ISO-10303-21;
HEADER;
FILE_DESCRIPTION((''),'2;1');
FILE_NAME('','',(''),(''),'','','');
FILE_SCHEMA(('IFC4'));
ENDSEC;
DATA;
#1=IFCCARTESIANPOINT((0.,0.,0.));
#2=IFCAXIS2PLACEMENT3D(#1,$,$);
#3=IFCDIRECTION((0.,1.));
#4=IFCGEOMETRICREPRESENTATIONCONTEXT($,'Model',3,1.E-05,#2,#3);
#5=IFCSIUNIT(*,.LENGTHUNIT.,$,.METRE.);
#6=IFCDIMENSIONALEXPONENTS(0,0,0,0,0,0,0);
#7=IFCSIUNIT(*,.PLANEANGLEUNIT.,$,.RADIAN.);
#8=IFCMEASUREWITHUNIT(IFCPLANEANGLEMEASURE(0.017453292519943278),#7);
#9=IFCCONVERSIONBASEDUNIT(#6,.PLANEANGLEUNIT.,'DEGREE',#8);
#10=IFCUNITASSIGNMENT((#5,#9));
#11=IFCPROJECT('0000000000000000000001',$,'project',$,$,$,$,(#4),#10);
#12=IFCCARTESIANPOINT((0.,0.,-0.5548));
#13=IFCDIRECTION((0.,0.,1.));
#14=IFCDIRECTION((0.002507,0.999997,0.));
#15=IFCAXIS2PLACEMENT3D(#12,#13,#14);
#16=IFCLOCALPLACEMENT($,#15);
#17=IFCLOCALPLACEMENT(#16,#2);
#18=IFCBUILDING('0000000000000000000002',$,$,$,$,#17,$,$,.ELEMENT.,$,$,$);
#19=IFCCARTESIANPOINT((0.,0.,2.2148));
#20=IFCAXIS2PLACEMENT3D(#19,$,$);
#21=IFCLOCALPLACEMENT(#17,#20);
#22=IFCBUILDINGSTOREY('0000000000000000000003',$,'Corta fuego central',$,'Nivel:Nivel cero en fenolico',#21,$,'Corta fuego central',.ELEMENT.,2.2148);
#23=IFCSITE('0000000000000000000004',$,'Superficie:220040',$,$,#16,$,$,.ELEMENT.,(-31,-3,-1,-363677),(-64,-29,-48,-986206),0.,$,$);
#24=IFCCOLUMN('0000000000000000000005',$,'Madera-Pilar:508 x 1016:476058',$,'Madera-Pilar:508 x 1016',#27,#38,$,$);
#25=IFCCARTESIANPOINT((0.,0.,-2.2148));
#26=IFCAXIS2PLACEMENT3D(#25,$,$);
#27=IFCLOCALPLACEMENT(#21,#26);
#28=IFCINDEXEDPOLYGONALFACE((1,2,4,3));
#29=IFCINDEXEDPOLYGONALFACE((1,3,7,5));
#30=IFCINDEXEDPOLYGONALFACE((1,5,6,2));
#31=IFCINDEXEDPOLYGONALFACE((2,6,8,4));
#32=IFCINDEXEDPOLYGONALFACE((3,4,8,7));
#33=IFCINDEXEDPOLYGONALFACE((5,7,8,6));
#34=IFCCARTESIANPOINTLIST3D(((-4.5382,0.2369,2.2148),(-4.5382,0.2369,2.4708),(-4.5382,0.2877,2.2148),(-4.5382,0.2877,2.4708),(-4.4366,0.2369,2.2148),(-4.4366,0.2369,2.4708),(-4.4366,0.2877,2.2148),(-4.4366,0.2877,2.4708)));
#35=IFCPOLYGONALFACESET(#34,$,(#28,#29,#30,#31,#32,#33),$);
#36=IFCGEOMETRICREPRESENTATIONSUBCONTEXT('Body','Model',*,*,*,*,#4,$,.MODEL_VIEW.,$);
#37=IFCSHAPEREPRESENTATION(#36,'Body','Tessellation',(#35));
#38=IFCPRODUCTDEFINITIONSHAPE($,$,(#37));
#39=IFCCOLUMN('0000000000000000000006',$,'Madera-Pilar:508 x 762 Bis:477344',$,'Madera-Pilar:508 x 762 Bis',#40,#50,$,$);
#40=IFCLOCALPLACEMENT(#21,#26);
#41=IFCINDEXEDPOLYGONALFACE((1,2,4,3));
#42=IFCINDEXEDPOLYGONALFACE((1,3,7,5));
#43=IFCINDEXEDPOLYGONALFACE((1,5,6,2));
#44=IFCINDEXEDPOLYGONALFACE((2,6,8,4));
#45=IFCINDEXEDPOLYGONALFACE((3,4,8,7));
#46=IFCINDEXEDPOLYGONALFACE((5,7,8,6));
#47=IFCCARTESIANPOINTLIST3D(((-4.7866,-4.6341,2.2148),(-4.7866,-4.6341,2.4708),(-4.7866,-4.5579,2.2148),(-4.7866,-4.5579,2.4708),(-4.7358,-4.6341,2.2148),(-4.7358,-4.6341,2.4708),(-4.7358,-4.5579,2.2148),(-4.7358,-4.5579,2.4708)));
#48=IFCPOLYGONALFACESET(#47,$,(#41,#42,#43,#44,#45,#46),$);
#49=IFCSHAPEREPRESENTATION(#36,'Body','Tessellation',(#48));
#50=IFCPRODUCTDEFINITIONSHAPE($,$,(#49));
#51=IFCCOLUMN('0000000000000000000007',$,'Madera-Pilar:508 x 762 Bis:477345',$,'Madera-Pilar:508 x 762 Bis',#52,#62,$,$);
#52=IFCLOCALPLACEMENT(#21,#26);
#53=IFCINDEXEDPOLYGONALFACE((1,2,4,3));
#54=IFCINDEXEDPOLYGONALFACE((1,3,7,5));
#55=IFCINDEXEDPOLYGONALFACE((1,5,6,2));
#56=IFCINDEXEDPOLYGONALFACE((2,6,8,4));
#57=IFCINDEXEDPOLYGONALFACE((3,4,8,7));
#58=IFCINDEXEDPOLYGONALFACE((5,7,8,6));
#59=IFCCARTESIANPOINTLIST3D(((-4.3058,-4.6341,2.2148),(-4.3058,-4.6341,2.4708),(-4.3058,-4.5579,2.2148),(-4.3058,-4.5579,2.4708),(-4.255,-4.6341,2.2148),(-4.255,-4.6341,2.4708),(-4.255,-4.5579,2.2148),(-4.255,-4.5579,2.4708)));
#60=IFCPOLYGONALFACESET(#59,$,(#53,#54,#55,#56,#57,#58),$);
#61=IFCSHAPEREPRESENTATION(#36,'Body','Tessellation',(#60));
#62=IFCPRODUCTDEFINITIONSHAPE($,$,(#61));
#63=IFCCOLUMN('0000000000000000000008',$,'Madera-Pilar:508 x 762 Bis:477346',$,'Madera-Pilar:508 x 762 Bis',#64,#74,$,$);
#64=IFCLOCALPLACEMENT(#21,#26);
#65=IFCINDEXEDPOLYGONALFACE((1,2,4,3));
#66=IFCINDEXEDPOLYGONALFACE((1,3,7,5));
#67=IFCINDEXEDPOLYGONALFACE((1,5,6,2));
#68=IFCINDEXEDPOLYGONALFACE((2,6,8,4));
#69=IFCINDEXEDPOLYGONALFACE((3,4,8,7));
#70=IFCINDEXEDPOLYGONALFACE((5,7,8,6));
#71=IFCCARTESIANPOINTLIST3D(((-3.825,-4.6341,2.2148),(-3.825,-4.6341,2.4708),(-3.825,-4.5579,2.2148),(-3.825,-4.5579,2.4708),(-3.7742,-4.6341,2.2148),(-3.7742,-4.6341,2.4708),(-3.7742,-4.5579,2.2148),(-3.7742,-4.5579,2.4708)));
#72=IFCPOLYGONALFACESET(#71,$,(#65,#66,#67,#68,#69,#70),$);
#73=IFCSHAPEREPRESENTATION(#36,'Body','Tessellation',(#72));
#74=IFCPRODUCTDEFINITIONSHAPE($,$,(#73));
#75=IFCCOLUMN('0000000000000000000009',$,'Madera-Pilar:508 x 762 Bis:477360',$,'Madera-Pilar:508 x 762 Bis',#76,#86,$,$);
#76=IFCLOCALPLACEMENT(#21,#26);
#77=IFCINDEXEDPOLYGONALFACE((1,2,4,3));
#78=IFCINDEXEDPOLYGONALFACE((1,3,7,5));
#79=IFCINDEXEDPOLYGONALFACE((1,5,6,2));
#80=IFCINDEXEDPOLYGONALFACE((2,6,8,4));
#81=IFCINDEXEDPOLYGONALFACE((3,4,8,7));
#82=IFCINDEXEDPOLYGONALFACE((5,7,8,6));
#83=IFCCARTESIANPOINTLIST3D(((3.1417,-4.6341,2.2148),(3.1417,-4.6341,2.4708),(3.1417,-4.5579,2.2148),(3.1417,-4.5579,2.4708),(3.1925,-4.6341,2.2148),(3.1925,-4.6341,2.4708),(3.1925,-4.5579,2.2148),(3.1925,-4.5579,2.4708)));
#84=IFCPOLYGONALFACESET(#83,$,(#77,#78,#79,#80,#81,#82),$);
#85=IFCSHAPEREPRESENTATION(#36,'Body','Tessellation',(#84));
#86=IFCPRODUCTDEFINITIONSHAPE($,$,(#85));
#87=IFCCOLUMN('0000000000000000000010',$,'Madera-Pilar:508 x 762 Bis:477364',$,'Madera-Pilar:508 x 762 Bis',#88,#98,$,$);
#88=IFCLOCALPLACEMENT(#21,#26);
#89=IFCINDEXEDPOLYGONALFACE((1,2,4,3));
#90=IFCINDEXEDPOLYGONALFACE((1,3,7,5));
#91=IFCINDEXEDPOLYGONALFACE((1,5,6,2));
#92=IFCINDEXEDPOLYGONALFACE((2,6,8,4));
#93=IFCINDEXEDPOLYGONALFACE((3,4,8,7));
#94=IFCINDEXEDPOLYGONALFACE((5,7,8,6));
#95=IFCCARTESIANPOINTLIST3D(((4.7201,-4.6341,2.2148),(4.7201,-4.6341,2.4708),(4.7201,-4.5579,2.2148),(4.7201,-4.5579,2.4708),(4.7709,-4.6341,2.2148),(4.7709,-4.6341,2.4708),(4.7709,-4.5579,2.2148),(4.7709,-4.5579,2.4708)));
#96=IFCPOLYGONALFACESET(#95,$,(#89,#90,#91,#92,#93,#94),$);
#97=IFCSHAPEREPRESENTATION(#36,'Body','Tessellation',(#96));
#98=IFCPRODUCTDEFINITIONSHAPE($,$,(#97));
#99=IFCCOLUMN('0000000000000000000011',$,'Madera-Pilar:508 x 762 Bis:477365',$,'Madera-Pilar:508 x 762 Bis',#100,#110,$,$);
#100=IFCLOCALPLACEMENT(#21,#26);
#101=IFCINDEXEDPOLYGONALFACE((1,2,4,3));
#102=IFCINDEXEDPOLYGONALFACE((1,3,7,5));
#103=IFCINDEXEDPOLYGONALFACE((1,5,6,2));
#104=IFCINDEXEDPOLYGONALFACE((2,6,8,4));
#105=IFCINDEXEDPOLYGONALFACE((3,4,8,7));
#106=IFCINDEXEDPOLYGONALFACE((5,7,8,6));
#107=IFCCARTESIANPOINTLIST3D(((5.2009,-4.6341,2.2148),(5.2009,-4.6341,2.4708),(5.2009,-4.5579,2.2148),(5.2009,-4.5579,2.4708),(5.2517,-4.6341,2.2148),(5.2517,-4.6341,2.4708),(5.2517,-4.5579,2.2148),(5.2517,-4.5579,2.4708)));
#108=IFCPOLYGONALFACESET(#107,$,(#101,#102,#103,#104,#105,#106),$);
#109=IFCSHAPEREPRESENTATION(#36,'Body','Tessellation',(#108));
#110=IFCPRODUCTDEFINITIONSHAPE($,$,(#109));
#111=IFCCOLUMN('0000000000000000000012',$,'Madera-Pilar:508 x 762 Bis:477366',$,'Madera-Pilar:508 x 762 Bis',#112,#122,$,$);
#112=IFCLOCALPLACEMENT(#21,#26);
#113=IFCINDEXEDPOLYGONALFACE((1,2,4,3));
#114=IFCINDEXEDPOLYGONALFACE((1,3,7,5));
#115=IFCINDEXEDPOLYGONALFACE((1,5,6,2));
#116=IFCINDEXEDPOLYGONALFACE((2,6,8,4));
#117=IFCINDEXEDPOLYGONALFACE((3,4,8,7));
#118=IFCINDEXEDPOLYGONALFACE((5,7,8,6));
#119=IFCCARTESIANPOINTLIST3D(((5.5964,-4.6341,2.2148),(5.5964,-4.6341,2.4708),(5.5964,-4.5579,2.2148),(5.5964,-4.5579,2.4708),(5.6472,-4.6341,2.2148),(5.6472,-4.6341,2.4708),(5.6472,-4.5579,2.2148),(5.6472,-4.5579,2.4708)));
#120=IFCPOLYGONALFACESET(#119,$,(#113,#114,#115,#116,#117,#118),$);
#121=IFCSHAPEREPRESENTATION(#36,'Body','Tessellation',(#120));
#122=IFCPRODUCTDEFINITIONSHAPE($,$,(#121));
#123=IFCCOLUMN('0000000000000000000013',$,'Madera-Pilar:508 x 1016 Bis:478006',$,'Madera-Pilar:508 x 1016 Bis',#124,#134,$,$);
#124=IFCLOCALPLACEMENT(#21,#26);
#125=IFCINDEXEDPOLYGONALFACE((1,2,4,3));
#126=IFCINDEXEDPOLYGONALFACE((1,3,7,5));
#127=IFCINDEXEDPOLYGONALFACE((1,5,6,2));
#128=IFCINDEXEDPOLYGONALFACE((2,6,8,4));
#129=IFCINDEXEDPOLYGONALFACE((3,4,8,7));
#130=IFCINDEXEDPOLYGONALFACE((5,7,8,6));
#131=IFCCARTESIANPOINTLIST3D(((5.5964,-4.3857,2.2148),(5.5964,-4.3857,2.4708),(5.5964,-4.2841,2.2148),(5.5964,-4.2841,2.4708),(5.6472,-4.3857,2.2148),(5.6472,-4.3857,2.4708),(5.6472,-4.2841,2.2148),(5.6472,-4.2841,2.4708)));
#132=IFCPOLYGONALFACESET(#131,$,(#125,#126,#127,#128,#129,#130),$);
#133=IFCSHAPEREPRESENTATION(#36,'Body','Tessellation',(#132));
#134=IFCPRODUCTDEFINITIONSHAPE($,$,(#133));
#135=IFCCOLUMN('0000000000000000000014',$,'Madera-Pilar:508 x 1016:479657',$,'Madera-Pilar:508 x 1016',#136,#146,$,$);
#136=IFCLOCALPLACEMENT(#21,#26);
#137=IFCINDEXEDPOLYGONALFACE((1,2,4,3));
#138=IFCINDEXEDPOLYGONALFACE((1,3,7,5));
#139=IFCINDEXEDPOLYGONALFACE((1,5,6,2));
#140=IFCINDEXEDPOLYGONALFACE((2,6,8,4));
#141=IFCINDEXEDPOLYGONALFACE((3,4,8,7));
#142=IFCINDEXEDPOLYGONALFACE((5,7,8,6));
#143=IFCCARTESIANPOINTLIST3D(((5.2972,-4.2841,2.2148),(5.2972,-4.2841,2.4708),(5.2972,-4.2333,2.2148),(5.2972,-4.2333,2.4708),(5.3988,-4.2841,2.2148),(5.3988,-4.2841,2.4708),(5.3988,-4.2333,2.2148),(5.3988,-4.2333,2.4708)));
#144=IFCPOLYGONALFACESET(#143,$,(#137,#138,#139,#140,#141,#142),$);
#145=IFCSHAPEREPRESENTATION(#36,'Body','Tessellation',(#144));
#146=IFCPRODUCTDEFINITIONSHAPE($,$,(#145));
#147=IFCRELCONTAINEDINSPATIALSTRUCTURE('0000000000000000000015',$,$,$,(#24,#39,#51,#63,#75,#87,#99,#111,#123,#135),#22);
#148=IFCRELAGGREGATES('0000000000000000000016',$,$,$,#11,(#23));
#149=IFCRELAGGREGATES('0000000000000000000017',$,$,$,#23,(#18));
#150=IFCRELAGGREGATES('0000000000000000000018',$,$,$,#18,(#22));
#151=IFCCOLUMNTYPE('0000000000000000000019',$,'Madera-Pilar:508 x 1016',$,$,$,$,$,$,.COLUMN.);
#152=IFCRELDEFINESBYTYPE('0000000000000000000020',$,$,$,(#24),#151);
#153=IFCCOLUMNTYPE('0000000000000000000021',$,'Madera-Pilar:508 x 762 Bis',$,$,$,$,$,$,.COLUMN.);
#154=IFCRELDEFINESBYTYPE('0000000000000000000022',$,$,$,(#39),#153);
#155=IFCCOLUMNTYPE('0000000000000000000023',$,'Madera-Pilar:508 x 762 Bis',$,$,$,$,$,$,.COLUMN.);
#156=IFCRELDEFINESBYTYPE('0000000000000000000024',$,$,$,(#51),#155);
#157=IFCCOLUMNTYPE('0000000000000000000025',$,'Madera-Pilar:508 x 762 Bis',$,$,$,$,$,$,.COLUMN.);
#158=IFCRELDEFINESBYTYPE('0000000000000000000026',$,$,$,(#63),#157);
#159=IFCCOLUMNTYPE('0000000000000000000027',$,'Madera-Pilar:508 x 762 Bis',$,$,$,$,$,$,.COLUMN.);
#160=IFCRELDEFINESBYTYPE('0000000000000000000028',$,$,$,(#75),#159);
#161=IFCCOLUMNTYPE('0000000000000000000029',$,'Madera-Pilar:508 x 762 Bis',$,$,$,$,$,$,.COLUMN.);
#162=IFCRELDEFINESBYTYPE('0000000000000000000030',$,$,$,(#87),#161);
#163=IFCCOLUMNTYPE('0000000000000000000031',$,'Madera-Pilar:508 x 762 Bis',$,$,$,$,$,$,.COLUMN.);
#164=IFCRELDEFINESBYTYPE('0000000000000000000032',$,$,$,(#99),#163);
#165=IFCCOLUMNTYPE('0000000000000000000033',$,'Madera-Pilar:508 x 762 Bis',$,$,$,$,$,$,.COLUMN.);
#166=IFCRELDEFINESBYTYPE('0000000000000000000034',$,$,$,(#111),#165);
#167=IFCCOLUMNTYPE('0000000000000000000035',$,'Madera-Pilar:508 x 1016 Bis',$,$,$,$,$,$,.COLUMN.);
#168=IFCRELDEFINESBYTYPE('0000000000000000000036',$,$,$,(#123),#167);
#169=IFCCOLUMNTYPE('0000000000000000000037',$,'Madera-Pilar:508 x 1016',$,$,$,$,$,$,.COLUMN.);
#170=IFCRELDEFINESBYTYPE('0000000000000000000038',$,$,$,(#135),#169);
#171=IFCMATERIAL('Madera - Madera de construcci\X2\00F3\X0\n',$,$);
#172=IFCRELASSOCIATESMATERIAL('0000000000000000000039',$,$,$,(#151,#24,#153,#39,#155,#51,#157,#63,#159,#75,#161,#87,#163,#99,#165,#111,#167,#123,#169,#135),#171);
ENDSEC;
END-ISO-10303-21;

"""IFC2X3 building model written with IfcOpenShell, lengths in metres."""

from ifc_helpers import new_model, entity, si_unit, converted_unit, direction, frame, frame_2d, origin, origin_2d_with_axis, place, context, subcontext, project, spatial, rectangle, extrude, source, transform, mapped, material, type_object, type_shapes, element, save


model = new_model("IFC2X3")

# Units and contexts
model_context = context("Model", 3, precision=1e-05, world=origin(), true_north=direction((0.0, 1.0)))
body_context = subcontext(model_context, "Body", "Model", "MODEL_VIEW")
ifc_project = project(units=[si_unit("LENGTHUNIT", "METRE"), converted_unit("PLANEANGLEUNIT", "DEGREE", entity("IfcPlaneAngleMeasure", 0.017453292519943278), si_unit("PLANEANGLEUNIT", "RADIAN"), dimensions=[0, 0, 0, 0, 0, 0, 0])], contexts=[model_context])

# Site, building, storey
site_placement = place(None, frame((0.0, 0.0, -0.5548), z_axis=(0.0, 0.0, 1.0), x_axis=(0.002507, 0.999997, 0.0)))
site = spatial("IfcSite", under=ifc_project, at=site_placement, Name="Superficie:220040", CompositionType="ELEMENT", RefLatitude=(-31, -3, -1, -363677), RefLongitude=(-64, -29, -48, -986206), RefElevation=0.0)
building_placement = place(site_placement, origin())
building = spatial("IfcBuilding", under=site, at=building_placement, CompositionType="ELEMENT")
storey_placement = place(building_placement, frame((0.0, 0.0, 2.2148)))
storey = spatial("IfcBuildingStorey", under=building, at=storey_placement, Name="Corta fuego central", ObjectType="Nivel:Nivel cero en fenolico", LongName="Corta fuego central", CompositionType="ELEMENT", Elevation=2.2148)

# Columns
ifc_material = material(Name="Madera - Madera de construcción")
column_type_1 = type_object("IfcColumnType", Name="Madera-Pilar:508 x 1016", PredefinedType="COLUMN", material=ifc_material)
shared_shape_1 = source(origin(), body_context, "Body", "SweptSolid", [
    extrude(rectangle(XDim=0.1016, YDim=0.0508, at=frame_2d((0.0, 0.0), x_axis=(1.0, 0.0))), frame((-4.4874, 0.2623, 2.2148), z_axis=(0.0, 0.0, 1.0), x_axis=(-1.0, 0.0, 0.0)), (0.0, 0.0, 1.0), 0.256),
])
type_shapes(column_type_1, [shared_shape_1])
column_1_placement = place(storey_placement, frame((0.0, 0.0, -2.2148)))
element("IfcColumn", 1, at=column_1_placement, inside=storey, type_object=column_type_1, material=ifc_material, Name="Madera-Pilar:508 x 1016:476058", ObjectType="Madera-Pilar:508 x 1016", context=body_context, shape_type="MappedRepresentation", body=[
    mapped(shared_shape_1, transform((0.0, 0.0, 0.0), scale=1.0)),
])
column_type_2 = type_object("IfcColumnType", Name="Madera-Pilar:508 x 762 Bis", PredefinedType="COLUMN", material=ifc_material)
shared_shape_2 = source(origin(), body_context, "Body", "SweptSolid", [
    extrude(rectangle(XDim=0.0508, YDim=0.0762, at=frame_2d((0.0, 0.0), x_axis=(1.0, 0.0))), frame((-4.7612, -4.596, 2.2148)), (0.0, 0.0, 1.0), 0.256),
])
type_shapes(column_type_2, [shared_shape_2])
column_2_placement = place(storey_placement, frame((0.0, 0.0, -2.2148)))
element("IfcColumn", 2, at=column_2_placement, inside=storey, type_object=column_type_2, material=ifc_material, Name="Madera-Pilar:508 x 762 Bis:477344", ObjectType="Madera-Pilar:508 x 762 Bis", context=body_context, shape_type="MappedRepresentation", body=[
    mapped(shared_shape_2, transform((0.0, 0.0, 0.0), scale=1.0)),
])
column_type_3 = type_object("IfcColumnType", Name="Madera-Pilar:508 x 762 Bis", PredefinedType="COLUMN", material=ifc_material)
shared_shape_3 = source(origin(), body_context, "Body", "SweptSolid", [
    extrude(rectangle(XDim=0.0508, YDim=0.0762, at=frame_2d((0.0, 0.0), x_axis=(1.0, 0.0))), frame((-4.2804, -4.596, 2.2148)), (0.0, 0.0, 1.0), 0.256),
])
type_shapes(column_type_3, [shared_shape_3])
column_3_placement = place(storey_placement, frame((0.0, 0.0, -2.2148)))
element("IfcColumn", 3, at=column_3_placement, inside=storey, type_object=column_type_3, material=ifc_material, Name="Madera-Pilar:508 x 762 Bis:477345", ObjectType="Madera-Pilar:508 x 762 Bis", context=body_context, shape_type="MappedRepresentation", body=[
    mapped(shared_shape_3, transform((0.0, 0.0, 0.0), scale=1.0)),
])
column_type_4 = type_object("IfcColumnType", Name="Madera-Pilar:508 x 762 Bis", PredefinedType="COLUMN", material=ifc_material)
shared_shape_4 = source(origin(), body_context, "Body", "SweptSolid", [
    extrude(rectangle(XDim=0.0508, YDim=0.0762, at=frame_2d((0.0, 0.0), x_axis=(1.0, 0.0))), frame((-3.7996, -4.596, 2.2148)), (0.0, 0.0, 1.0), 0.256),
])
type_shapes(column_type_4, [shared_shape_4])
column_4_placement = place(storey_placement, frame((0.0, 0.0, -2.2148)))
element("IfcColumn", 4, at=column_4_placement, inside=storey, type_object=column_type_4, material=ifc_material, Name="Madera-Pilar:508 x 762 Bis:477346", ObjectType="Madera-Pilar:508 x 762 Bis", context=body_context, shape_type="MappedRepresentation", body=[
    mapped(shared_shape_4, transform((0.0, 0.0, 0.0), scale=1.0)),
])
column_type_5 = type_object("IfcColumnType", Name="Madera-Pilar:508 x 762 Bis", PredefinedType="COLUMN", material=ifc_material)
shared_shape_5 = source(origin(), body_context, "Body", "SweptSolid", [
    extrude(rectangle(XDim=0.0508, YDim=0.0762, at=frame_2d((0.0, 0.0), x_axis=(1.0, 0.0))), frame((3.1671, -4.596, 2.2148)), (0.0, 0.0, 1.0), 0.256),
])
type_shapes(column_type_5, [shared_shape_5])
column_5_placement = place(storey_placement, frame((0.0, 0.0, -2.2148)))
element("IfcColumn", 5, at=column_5_placement, inside=storey, type_object=column_type_5, material=ifc_material, Name="Madera-Pilar:508 x 762 Bis:477360", ObjectType="Madera-Pilar:508 x 762 Bis", context=body_context, shape_type="MappedRepresentation", body=[
    mapped(shared_shape_5, transform((0.0, 0.0, 0.0), scale=1.0)),
])
column_type_6 = type_object("IfcColumnType", Name="Madera-Pilar:508 x 762 Bis", PredefinedType="COLUMN", material=ifc_material)
shared_shape_6 = source(origin(), body_context, "Body", "SweptSolid", [
    extrude(rectangle(XDim=0.0508, YDim=0.0762, at=frame_2d((0.0, 0.0), x_axis=(1.0, 0.0))), frame((4.7455, -4.596, 2.2148)), (0.0, 0.0, 1.0), 0.256),
])
type_shapes(column_type_6, [shared_shape_6])
column_6_placement = place(storey_placement, frame((0.0, 0.0, -2.2148)))
element("IfcColumn", 6, at=column_6_placement, inside=storey, type_object=column_type_6, material=ifc_material, Name="Madera-Pilar:508 x 762 Bis:477364", ObjectType="Madera-Pilar:508 x 762 Bis", context=body_context, shape_type="MappedRepresentation", body=[
    mapped(shared_shape_6, transform((0.0, 0.0, 0.0), scale=1.0)),
])
column_type_7 = type_object("IfcColumnType", Name="Madera-Pilar:508 x 762 Bis", PredefinedType="COLUMN", material=ifc_material)
shared_shape_7 = source(origin(), body_context, "Body", "SweptSolid", [
    extrude(rectangle(XDim=0.0508, YDim=0.0762, at=origin_2d_with_axis()), frame((5.2263, -4.596, 2.2148)), (0.0, 0.0, 1.0), 0.256),
])
type_shapes(column_type_7, [shared_shape_7])
column_7_placement = place(storey_placement, frame((0.0, 0.0, -2.2148)))
element("IfcColumn", 7, at=column_7_placement, inside=storey, type_object=column_type_7, material=ifc_material, Name="Madera-Pilar:508 x 762 Bis:477365", ObjectType="Madera-Pilar:508 x 762 Bis", context=body_context, shape_type="MappedRepresentation", body=[
    mapped(shared_shape_7, transform((0.0, 0.0, 0.0), scale=1.0)),
])
column_type_8 = type_object("IfcColumnType", Name="Madera-Pilar:508 x 762 Bis", PredefinedType="COLUMN", material=ifc_material)
shared_shape_8 = source(origin(), body_context, "Body", "SweptSolid", [
    extrude(rectangle(XDim=0.0508, YDim=0.0762, at=origin_2d_with_axis()), frame((5.6218, -4.596, 2.2148)), (0.0, 0.0, 1.0), 0.256),
])
type_shapes(column_type_8, [shared_shape_8])
column_8_placement = place(storey_placement, frame((0.0, 0.0, -2.2148)))
element("IfcColumn", 8, at=column_8_placement, inside=storey, type_object=column_type_8, material=ifc_material, Name="Madera-Pilar:508 x 762 Bis:477366", ObjectType="Madera-Pilar:508 x 762 Bis", context=body_context, shape_type="MappedRepresentation", body=[
    mapped(shared_shape_8, transform((0.0, 0.0, 0.0), scale=1.0)),
])
column_type_9 = type_object("IfcColumnType", Name="Madera-Pilar:508 x 1016 Bis", PredefinedType="COLUMN", material=ifc_material)
shared_shape_9 = source(origin(), body_context, "Body", "SweptSolid", [
    extrude(rectangle(XDim=0.0508, YDim=0.1016, at=frame_2d((0.0, 0.0), x_axis=(1.0, 0.0))), frame((5.6218, -4.3349, 2.2148), z_axis=(0.0, 0.0, 1.0), x_axis=(-1.0, 0.0, 0.0)), (0.0, 0.0, 1.0), 0.256),
])
type_shapes(column_type_9, [shared_shape_9])
column_9_placement = place(storey_placement, frame((0.0, 0.0, -2.2148)))
element("IfcColumn", 9, at=column_9_placement, inside=storey, type_object=column_type_9, material=ifc_material, Name="Madera-Pilar:508 x 1016 Bis:478006", ObjectType="Madera-Pilar:508 x 1016 Bis", context=body_context, shape_type="MappedRepresentation", body=[
    mapped(shared_shape_9, transform((0.0, 0.0, 0.0), scale=1.0)),
])
column_type_10 = type_object("IfcColumnType", Name="Madera-Pilar:508 x 1016", PredefinedType="COLUMN", material=ifc_material)
shared_shape_10 = source(origin(), body_context, "Body", "SweptSolid", [
    extrude(rectangle(XDim=0.1016, YDim=0.0508, at=frame_2d((0.0, 0.0), x_axis=(1.0, 0.0))), frame((5.348, -4.2587, 2.2148), z_axis=(0.0, 0.0, 1.0), x_axis=(-1.0, 0.0, 0.0)), (0.0, 0.0, 1.0), 0.256),
])
type_shapes(column_type_10, [shared_shape_10])
column_10_placement = place(storey_placement, frame((0.0, 0.0, -2.2148)))
element("IfcColumn", 10, at=column_10_placement, inside=storey, type_object=column_type_10, material=ifc_material, Name="Madera-Pilar:508 x 1016:479657", ObjectType="Madera-Pilar:508 x 1016", context=body_context, shape_type="MappedRepresentation", body=[
    mapped(shared_shape_10, transform((0.0, 0.0, 0.0), scale=1.0)),
])

save(model, "model.ifc")
